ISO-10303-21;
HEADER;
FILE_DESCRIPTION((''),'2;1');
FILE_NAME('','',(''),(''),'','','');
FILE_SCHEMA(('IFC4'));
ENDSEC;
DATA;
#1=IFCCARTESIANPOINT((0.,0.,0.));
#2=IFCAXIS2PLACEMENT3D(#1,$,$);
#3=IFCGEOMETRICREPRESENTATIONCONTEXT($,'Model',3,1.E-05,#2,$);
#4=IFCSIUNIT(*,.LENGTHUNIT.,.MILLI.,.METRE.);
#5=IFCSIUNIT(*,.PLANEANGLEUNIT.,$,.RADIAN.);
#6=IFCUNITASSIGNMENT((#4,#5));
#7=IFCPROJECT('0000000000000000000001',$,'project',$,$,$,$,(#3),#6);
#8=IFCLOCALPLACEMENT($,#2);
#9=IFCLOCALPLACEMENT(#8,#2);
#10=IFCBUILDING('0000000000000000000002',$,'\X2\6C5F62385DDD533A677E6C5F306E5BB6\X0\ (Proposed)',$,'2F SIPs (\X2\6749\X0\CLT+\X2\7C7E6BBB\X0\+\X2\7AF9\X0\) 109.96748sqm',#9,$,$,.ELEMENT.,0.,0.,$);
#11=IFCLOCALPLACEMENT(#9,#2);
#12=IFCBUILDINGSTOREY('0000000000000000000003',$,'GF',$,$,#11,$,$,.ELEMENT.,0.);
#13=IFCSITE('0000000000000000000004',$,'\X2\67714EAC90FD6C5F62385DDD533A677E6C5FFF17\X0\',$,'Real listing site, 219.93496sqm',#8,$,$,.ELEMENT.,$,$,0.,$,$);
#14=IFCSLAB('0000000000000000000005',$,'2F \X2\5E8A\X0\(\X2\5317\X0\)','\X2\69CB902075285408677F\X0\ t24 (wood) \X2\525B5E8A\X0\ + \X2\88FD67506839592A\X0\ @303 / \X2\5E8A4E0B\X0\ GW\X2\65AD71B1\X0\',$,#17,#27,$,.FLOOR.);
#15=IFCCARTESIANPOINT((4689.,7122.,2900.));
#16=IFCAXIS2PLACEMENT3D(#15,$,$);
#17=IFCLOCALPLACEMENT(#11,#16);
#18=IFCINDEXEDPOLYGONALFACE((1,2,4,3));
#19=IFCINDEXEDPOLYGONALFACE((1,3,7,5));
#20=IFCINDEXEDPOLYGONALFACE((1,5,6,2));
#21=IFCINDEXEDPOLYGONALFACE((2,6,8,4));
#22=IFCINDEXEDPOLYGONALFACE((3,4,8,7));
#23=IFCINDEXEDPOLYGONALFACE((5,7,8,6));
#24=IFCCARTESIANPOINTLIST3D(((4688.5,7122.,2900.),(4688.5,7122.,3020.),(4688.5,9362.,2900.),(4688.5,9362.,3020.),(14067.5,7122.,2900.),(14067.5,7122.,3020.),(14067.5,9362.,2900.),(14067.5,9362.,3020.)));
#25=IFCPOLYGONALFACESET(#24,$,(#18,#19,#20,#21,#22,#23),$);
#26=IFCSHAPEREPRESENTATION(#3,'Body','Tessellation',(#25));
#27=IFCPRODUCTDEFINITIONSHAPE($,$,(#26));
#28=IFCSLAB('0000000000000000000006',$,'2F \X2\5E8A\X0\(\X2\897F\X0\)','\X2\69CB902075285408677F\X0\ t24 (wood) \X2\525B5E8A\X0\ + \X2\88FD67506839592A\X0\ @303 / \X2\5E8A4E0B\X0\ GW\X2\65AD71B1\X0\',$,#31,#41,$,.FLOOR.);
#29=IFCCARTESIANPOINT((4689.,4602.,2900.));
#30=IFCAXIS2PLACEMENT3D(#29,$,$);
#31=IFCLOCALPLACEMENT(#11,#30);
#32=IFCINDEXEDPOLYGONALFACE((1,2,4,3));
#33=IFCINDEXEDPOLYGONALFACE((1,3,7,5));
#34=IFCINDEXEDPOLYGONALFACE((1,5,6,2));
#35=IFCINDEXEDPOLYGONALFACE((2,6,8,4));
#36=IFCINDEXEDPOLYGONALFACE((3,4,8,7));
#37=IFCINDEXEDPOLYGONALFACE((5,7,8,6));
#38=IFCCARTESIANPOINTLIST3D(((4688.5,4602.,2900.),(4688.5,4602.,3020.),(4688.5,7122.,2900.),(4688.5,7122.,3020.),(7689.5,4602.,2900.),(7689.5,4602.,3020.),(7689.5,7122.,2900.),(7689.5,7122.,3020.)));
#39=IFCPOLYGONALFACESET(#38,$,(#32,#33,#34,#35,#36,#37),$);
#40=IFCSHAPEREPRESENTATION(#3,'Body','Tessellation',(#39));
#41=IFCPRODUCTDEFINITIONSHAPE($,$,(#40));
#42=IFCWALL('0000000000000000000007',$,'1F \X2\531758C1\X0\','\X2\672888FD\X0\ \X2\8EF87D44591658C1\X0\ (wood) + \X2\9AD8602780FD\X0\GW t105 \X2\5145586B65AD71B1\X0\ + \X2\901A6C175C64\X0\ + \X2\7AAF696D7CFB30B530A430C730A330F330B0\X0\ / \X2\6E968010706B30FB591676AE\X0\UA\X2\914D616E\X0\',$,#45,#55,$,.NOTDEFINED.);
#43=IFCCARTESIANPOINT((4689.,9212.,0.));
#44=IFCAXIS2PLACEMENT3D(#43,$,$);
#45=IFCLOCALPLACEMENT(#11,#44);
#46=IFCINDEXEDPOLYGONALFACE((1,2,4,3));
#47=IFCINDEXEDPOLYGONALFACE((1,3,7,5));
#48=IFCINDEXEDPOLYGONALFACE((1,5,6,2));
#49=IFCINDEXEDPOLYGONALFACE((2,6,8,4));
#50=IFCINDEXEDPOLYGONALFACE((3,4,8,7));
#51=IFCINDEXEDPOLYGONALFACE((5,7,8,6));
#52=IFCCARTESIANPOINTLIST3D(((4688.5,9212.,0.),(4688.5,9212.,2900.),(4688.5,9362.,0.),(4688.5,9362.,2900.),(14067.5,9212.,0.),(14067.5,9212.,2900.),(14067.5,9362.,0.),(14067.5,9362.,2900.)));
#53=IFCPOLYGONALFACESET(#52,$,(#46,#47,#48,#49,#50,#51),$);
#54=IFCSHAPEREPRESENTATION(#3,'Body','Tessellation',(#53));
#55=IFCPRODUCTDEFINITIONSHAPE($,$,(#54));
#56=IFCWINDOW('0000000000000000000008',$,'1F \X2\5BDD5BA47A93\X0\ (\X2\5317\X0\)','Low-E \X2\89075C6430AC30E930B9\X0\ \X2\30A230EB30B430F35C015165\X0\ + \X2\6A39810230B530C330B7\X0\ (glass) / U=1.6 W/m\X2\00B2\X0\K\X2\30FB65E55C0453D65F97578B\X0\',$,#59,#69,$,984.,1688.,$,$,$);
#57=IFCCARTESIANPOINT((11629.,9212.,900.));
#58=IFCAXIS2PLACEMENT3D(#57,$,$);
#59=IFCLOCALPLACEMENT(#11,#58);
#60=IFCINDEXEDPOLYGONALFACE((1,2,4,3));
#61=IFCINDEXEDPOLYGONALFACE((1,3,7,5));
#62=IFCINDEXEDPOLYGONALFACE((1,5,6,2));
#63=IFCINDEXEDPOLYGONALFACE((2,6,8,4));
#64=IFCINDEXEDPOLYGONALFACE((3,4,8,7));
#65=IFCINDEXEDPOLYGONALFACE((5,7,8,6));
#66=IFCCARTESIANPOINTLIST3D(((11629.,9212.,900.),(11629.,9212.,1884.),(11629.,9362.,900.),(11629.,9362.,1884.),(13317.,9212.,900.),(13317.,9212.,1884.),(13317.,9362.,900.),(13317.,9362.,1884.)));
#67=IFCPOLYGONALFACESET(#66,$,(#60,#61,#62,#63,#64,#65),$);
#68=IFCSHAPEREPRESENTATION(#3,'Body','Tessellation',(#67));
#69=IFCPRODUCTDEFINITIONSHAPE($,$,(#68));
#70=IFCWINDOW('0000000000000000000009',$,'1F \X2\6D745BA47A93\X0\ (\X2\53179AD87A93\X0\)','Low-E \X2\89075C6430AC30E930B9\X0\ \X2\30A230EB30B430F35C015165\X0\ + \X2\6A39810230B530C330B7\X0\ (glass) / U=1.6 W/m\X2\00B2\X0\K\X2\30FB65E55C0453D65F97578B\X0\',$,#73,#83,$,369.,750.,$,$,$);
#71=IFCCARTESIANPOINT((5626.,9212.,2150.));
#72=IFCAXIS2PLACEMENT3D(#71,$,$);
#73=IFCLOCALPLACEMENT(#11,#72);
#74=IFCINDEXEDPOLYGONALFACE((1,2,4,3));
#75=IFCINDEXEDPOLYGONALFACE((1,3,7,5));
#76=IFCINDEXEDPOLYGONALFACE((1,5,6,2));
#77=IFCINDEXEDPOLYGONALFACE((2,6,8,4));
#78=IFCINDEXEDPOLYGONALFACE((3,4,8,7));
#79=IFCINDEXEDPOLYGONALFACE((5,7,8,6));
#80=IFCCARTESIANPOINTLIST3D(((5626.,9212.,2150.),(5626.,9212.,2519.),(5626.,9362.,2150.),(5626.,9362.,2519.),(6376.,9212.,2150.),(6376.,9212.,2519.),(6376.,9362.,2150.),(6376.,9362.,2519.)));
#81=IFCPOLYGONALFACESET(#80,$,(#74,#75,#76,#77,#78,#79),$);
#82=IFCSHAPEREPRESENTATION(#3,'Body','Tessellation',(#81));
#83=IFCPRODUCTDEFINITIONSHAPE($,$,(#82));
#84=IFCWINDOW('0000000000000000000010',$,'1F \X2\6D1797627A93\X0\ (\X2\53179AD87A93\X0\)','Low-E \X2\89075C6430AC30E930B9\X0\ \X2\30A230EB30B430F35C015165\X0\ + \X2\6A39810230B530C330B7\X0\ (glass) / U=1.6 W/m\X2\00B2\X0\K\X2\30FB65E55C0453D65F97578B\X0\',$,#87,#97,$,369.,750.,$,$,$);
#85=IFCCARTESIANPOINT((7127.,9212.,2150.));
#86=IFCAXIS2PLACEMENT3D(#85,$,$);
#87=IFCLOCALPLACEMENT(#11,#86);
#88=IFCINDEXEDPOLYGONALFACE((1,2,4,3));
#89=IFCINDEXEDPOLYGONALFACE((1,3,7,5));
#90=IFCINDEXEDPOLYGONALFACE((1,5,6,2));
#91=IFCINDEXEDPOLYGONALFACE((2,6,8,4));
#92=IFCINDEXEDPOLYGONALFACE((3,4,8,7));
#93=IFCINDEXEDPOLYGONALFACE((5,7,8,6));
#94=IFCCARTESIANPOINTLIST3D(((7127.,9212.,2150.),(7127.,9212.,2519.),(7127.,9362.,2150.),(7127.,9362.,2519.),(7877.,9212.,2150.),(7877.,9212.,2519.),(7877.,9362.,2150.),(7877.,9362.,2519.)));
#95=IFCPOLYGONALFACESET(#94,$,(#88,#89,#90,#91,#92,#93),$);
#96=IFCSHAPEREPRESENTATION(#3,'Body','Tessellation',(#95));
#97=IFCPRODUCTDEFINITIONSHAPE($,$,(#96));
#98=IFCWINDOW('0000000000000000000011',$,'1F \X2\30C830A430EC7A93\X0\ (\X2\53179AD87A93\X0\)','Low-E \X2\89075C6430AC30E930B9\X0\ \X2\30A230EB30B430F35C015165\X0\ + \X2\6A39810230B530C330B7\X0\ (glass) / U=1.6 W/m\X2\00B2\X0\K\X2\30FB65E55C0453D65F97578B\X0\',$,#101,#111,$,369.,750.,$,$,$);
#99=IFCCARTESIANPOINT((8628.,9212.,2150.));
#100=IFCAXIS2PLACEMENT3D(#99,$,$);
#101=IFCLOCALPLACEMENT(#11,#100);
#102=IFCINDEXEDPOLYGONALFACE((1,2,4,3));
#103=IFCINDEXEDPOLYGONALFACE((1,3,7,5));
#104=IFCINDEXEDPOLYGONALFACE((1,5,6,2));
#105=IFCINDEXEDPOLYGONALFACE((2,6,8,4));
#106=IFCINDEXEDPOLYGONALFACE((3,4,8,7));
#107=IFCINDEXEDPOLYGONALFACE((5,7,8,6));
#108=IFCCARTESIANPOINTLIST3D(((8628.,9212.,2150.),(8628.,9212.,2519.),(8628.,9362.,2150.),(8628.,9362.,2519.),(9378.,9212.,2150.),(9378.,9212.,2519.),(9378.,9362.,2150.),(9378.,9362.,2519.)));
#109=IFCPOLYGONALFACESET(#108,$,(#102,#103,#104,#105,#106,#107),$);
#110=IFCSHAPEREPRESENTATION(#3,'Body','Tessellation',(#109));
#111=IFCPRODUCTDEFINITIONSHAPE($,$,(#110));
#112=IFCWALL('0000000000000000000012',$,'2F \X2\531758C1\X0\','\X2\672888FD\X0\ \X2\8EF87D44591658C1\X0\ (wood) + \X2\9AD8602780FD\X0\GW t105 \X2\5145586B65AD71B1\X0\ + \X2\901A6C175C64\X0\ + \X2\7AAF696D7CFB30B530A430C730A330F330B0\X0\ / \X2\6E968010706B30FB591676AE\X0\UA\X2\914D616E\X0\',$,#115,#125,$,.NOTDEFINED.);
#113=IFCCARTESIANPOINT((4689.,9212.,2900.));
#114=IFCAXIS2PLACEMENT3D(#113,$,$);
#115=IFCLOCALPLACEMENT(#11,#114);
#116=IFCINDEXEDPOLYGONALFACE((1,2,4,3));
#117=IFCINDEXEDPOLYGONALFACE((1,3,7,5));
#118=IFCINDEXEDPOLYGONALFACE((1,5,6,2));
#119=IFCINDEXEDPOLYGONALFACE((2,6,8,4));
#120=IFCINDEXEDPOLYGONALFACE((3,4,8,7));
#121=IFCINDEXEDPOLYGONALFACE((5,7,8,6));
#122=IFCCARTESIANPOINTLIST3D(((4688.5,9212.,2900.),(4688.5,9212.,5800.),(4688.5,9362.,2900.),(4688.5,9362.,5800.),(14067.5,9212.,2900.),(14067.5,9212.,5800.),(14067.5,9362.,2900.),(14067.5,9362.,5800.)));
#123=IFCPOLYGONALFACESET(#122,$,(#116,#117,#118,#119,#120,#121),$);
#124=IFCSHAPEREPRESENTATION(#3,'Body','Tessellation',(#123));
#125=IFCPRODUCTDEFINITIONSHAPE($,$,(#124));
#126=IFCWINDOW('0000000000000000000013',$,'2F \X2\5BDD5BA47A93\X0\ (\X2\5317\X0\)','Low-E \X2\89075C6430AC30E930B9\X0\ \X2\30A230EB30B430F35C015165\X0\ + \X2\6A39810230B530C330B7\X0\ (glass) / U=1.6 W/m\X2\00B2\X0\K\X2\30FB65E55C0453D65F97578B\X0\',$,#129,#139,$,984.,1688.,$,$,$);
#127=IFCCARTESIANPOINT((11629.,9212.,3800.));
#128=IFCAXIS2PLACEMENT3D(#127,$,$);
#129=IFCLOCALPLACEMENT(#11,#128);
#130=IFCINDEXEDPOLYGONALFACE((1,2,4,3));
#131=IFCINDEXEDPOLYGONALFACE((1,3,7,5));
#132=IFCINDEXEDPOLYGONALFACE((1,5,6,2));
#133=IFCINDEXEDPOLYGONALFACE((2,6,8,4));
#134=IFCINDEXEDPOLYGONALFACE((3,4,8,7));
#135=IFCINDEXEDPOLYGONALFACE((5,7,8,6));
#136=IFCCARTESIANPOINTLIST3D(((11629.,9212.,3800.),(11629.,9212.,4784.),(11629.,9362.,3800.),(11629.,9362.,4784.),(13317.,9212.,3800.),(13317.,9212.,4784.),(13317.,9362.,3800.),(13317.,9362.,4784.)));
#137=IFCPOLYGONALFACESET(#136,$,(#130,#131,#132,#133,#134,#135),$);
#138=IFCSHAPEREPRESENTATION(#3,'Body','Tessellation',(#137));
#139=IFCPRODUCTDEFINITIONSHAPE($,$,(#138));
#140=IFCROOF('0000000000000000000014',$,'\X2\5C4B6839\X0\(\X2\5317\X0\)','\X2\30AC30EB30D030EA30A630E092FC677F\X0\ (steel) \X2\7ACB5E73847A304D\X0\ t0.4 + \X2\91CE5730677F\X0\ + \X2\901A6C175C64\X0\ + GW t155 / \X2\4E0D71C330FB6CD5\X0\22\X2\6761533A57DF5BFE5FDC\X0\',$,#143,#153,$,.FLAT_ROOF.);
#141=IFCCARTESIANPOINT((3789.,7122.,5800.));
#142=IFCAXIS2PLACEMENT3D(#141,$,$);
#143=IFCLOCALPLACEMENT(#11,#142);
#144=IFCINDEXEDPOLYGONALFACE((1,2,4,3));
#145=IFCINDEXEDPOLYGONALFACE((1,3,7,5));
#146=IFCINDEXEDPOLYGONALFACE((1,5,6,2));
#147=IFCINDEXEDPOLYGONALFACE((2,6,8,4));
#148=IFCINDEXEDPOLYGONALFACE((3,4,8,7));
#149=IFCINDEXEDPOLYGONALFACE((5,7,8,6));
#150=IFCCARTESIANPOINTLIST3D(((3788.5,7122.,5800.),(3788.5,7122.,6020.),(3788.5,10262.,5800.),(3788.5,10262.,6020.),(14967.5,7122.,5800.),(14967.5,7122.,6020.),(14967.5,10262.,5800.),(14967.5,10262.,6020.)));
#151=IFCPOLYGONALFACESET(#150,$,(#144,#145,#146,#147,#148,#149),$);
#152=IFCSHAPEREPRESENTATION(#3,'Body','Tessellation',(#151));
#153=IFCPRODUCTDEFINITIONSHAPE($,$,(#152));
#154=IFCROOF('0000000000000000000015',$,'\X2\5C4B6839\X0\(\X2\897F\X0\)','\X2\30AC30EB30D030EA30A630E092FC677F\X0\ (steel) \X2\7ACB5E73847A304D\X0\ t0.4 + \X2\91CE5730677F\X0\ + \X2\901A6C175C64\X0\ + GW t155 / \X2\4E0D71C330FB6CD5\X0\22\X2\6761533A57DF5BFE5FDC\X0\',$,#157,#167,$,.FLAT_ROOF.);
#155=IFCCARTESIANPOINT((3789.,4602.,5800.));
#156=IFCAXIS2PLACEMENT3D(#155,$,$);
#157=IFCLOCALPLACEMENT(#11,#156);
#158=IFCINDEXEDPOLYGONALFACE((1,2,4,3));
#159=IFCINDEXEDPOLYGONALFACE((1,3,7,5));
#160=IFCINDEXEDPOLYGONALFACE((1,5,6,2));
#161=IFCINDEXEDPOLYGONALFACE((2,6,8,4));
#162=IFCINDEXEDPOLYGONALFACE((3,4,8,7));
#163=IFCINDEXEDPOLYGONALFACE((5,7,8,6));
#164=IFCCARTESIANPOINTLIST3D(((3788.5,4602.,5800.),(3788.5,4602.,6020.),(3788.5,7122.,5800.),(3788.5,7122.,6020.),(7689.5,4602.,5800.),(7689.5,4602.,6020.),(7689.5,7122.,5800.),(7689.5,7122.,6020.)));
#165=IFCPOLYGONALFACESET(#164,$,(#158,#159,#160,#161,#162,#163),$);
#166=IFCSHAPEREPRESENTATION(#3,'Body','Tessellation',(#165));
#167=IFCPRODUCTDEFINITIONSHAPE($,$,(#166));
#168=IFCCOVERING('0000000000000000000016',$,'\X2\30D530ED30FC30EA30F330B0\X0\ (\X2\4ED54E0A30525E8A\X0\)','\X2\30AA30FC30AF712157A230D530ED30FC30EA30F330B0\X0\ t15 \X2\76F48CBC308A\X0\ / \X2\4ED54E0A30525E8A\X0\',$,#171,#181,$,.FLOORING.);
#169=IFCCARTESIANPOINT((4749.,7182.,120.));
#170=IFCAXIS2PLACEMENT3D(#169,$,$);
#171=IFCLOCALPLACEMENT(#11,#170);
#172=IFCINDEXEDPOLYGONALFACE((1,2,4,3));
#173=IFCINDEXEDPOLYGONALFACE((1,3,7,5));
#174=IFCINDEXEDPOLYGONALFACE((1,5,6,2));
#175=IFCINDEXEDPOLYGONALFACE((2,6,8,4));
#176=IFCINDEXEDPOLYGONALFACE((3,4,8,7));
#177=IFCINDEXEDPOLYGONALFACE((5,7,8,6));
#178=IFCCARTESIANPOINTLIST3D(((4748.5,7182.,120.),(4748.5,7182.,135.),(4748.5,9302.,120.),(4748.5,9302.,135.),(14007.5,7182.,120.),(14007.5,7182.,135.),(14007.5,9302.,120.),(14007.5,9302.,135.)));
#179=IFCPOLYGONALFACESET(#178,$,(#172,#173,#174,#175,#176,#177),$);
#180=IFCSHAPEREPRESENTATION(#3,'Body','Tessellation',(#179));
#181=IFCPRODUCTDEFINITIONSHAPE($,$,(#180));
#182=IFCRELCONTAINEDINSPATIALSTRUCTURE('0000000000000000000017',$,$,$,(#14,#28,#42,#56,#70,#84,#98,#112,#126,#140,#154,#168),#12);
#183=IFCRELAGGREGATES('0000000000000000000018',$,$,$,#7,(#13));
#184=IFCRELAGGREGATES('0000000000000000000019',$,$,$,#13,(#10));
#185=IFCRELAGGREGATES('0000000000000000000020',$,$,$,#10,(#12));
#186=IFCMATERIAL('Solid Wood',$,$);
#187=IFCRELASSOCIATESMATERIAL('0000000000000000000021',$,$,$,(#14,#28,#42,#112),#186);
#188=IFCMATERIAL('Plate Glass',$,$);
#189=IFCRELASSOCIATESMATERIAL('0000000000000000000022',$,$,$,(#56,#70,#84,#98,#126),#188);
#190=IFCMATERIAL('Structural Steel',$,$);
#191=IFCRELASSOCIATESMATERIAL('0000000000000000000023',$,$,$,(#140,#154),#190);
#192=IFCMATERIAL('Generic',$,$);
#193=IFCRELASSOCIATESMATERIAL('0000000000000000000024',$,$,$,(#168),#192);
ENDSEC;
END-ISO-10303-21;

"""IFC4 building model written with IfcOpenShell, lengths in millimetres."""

from ifc_helpers import new_model, si_unit, frame, frame_2d, origin, place, context, project, spatial, rectangle, extrude, material, element, fill, save


model = new_model("IFC4")

# Units and contexts
model_context = context("Model", 3, precision=1e-05, world=origin())
ifc_project = project(units=[si_unit("LENGTHUNIT", "METRE", prefix="MILLI"), si_unit("PLANEANGLEUNIT", "RADIAN")], contexts=[model_context])

# Site, building, storey
site_placement = place(None, origin())
site = spatial("IfcSite", under=ifc_project, at=site_placement, Name="東京都江戸川区松江７", ObjectType="Real listing site, 219.93496sqm", CompositionType="ELEMENT", RefElevation=0.0)
building_placement = place(site_placement, origin())
building = spatial("IfcBuilding", under=site, at=building_placement, Name="江戸川区松江の家 (Proposed)", ObjectType="2F SIPs (杉CLT+籾殻+竹) 109.96748sqm", CompositionType="ELEMENT", ElevationOfRefHeight=0.0, ElevationOfTerrain=0.0)
storey_placement = place(building_placement, origin())
storey = spatial("IfcBuildingStorey", under=building, at=storey_placement, Name="GF", CompositionType="ELEMENT", Elevation=0.0)

# Slabs
ifc_material_1 = material(Name="Solid Wood")
slab_1_placement = place(storey_placement, frame((4689.0, 7122.0, 2900.0)))
element("IfcSlab", 1, at=slab_1_placement, inside=storey, material=ifc_material_1, Name="2F 床(北)", Description="構造用合板 t24 (wood) 剛床 + 製材根太 @303 / 床下 GW断熱", PredefinedType="FLOOR", context=model_context, shape_type="SweptSolid", body=[
    extrude(rectangle(XDim=9379.0, YDim=2240.0, at=frame_2d((4689.0, 1120.0))), frame((4689.0, 7122.0, 2900.0)), (0.0, 0.0, 1.0), 120.0),
])
slab_2_placement = place(storey_placement, frame((4689.0, 4602.0, 2900.0)))
element("IfcSlab", 2, at=slab_2_placement, inside=storey, material=ifc_material_1, Name="2F 床(西)", Description="構造用合板 t24 (wood) 剛床 + 製材根太 @303 / 床下 GW断熱", PredefinedType="FLOOR", context=model_context, shape_type="SweptSolid", body=[
    extrude(rectangle(XDim=3001.0, YDim=2520.0, at=frame_2d((1500.0, 1260.0))), frame((4689.0, 4602.0, 2900.0)), (0.0, 0.0, 1.0), 120.0),
])

# Wall, openings, windows
wall_1_placement = place(storey_placement, frame((4689.0, 9212.0, 0.0)))
wall_1 = element("IfcWall", 3, at=wall_1_placement, inside=storey, material=ifc_material_1, Name="1F 北壁", Description="木製 軸組外壁 (wood) + 高性能GW t105 充填断熱 + 通気層 + 窯業系サイディング / 準耐火・外皮UA配慮", PredefinedType="NOTDEFINED", context=model_context, shape_type="SweptSolid", body=[
    extrude(rectangle(XDim=9379.0, YDim=150.0, at=frame_2d((4689.0, 75.0))), frame((4689.0, 9212.0, 0.0)), (0.0, 0.0, 1.0), 2900.0),
])
opening_1_placement = place(storey_placement, frame((11629.0, 9212.0, 900.0)))
opening_1 = element("IfcOpeningElement", 4, at=opening_1_placement, cuts=wall_1, PredefinedType="NOTDEFINED", context=model_context, shape_type="SweptSolid", body=[
    extrude(rectangle(XDim=1688.0, YDim=150.0, at=frame_2d((844.0, 75.0))), frame((11629.0, 9212.0, 900.0)), (0.0, 0.0, 1.0), 984.0),
])
opening_2_placement = place(storey_placement, frame((5626.0, 9212.0, 2150.0)))
opening_2 = element("IfcOpeningElement", 5, at=opening_2_placement, cuts=wall_1, PredefinedType="NOTDEFINED", context=model_context, shape_type="SweptSolid", body=[
    extrude(rectangle(XDim=750.0, YDim=150.0, at=frame_2d((375.0, 75.0))), frame((5626.0, 9212.0, 2150.0)), (0.0, 0.0, 1.0), 369.0),
])
opening_3_placement = place(storey_placement, frame((7127.0, 9212.0, 2150.0)))
opening_3 = element("IfcOpeningElement", 6, at=opening_3_placement, cuts=wall_1, PredefinedType="NOTDEFINED", context=model_context, shape_type="SweptSolid", body=[
    extrude(rectangle(XDim=750.0, YDim=150.0, at=frame_2d((375.0, 75.0))), frame((7127.0, 9212.0, 2150.0)), (0.0, 0.0, 1.0), 369.0),
])
opening_4_placement = place(storey_placement, frame((8628.0, 9212.0, 2150.0)))
opening_4 = element("IfcOpeningElement", 7, at=opening_4_placement, cuts=wall_1, PredefinedType="NOTDEFINED", context=model_context, shape_type="SweptSolid", body=[
    extrude(rectangle(XDim=750.0, YDim=150.0, at=frame_2d((375.0, 75.0))), frame((8628.0, 9212.0, 2150.0)), (0.0, 0.0, 1.0), 369.0),
])
ifc_material_2 = material(Name="Plate Glass")
window_1_placement = place(storey_placement, frame((11629.0, 9212.0, 900.0)))
window_1 = element("IfcWindow", 8, at=window_1_placement, inside=storey, material=ifc_material_2, Name="1F 寝室窓 (北)", Description="Low-E 複層ガラス アルゴン封入 + 樹脂サッシ (glass) / U=1.6 W/m²K・日射取得型", OverallHeight=984.0, OverallWidth=1688.0, context=model_context, shape_type="SweptSolid", body=[
    extrude(rectangle(XDim=1688.0, YDim=150.0, at=frame_2d((844.0, 75.0))), frame((11629.0, 9212.0, 900.0)), (0.0, 0.0, 1.0), 984.0),
])
fill(opening_1, window_1)
window_2_placement = place(storey_placement, frame((5626.0, 9212.0, 2150.0)))
window_2 = element("IfcWindow", 9, at=window_2_placement, inside=storey, material=ifc_material_2, Name="1F 浴室窓 (北高窓)", Description="Low-E 複層ガラス アルゴン封入 + 樹脂サッシ (glass) / U=1.6 W/m²K・日射取得型", OverallHeight=369.0, OverallWidth=750.0, context=model_context, shape_type="SweptSolid", body=[
    extrude(rectangle(XDim=750.0, YDim=150.0, at=frame_2d((375.0, 75.0))), frame((5626.0, 9212.0, 2150.0)), (0.0, 0.0, 1.0), 369.0),
])
fill(opening_2, window_2)
window_3_placement = place(storey_placement, frame((7127.0, 9212.0, 2150.0)))
window_3 = element("IfcWindow", 10, at=window_3_placement, inside=storey, material=ifc_material_2, Name="1F 洗面窓 (北高窓)", Description="Low-E 複層ガラス アルゴン封入 + 樹脂サッシ (glass) / U=1.6 W/m²K・日射取得型", OverallHeight=369.0, OverallWidth=750.0, context=model_context, shape_type="SweptSolid", body=[
    extrude(rectangle(XDim=750.0, YDim=150.0, at=frame_2d((375.0, 75.0))), frame((7127.0, 9212.0, 2150.0)), (0.0, 0.0, 1.0), 369.0),
])
fill(opening_3, window_3)
window_4_placement = place(storey_placement, frame((8628.0, 9212.0, 2150.0)))
window_4 = element("IfcWindow", 11, at=window_4_placement, inside=storey, material=ifc_material_2, Name="1F トイレ窓 (北高窓)", Description="Low-E 複層ガラス アルゴン封入 + 樹脂サッシ (glass) / U=1.6 W/m²K・日射取得型", OverallHeight=369.0, OverallWidth=750.0, context=model_context, shape_type="SweptSolid", body=[
    extrude(rectangle(XDim=750.0, YDim=150.0, at=frame_2d((375.0, 75.0))), frame((8628.0, 9212.0, 2150.0)), (0.0, 0.0, 1.0), 369.0),
])
fill(opening_4, window_4)

# Wall, opening, window
wall_2_placement = place(storey_placement, frame((4689.0, 9212.0, 2900.0)))
wall_2 = element("IfcWall", 12, at=wall_2_placement, inside=storey, material=ifc_material_1, Name="2F 北壁", Description="木製 軸組外壁 (wood) + 高性能GW t105 充填断熱 + 通気層 + 窯業系サイディング / 準耐火・外皮UA配慮", PredefinedType="NOTDEFINED", context=model_context, shape_type="SweptSolid", body=[
    extrude(rectangle(XDim=9379.0, YDim=150.0, at=frame_2d((4689.0, 75.0))), frame((4689.0, 9212.0, 2900.0)), (0.0, 0.0, 1.0), 2900.0),
])
opening_5_placement = place(storey_placement, frame((11629.0, 9212.0, 3800.0)))
opening_5 = element("IfcOpeningElement", 13, at=opening_5_placement, cuts=wall_2, PredefinedType="NOTDEFINED", context=model_context, shape_type="SweptSolid", body=[
    extrude(rectangle(XDim=1688.0, YDim=150.0, at=frame_2d((844.0, 75.0))), frame((11629.0, 9212.0, 3800.0)), (0.0, 0.0, 1.0), 984.0),
])
window_5_placement = place(storey_placement, frame((11629.0, 9212.0, 3800.0)))
window_5 = element("IfcWindow", 14, at=window_5_placement, inside=storey, material=ifc_material_2, Name="2F 寝室窓 (北)", Description="Low-E 複層ガラス アルゴン封入 + 樹脂サッシ (glass) / U=1.6 W/m²K・日射取得型", OverallHeight=984.0, OverallWidth=1688.0, context=model_context, shape_type="SweptSolid", body=[
    extrude(rectangle(XDim=1688.0, YDim=150.0, at=frame_2d((844.0, 75.0))), frame((11629.0, 9212.0, 3800.0)), (0.0, 0.0, 1.0), 984.0),
])
fill(opening_5, window_5)

# Roofs
ifc_material_3 = material(Name="Structural Steel")
for number, where, name in (
    (15, (3789.0, 7122.0, 5800.0), "屋根(北)"),
):
    element("IfcRoof", number, at=place(storey_placement, frame(where)), inside=storey, material=ifc_material_3, Name=name, Description="ガルバリウム鋼板 (steel) 立平葺き t0.4 + 野地板 + 通気層 + GW t155 / 不燃・法22条区域対応", PredefinedType="FLAT_ROOF", context=model_context, shape_type="SweptSolid", body=[
        extrude(rectangle(XDim=11179.0, YDim=3140.0, at=frame_2d((5589.0, 1570.0))), frame((3789.0, 7122.0, 5800.0)), (0.0, 0.0, 1.0), 220.0),
    ])
roof_placement = place(storey_placement, frame((3789.0, 4602.0, 5800.0)))
element("IfcRoof", 16, at=roof_placement, inside=storey, material=ifc_material_3, Name="屋根(西)", Description="ガルバリウム鋼板 (steel) 立平葺き t0.4 + 野地板 + 通気層 + GW t155 / 不燃・法22条区域対応", PredefinedType="FLAT_ROOF", context=model_context, shape_type="SweptSolid", body=[
    extrude(rectangle(XDim=3901.0, YDim=2520.0, at=frame_2d((1950.0, 1260.0))), frame((3789.0, 4602.0, 5800.0)), (0.0, 0.0, 1.0), 220.0),
])

# Covering
ifc_material_4 = material(Name="Generic")
covering_1_placement = place(storey_placement, frame((4749.0, 7182.0, 120.0)))
element("IfcCovering", 17, at=covering_1_placement, inside=storey, material=ifc_material_4, Name="フローリング (仕上げ床)", Description="オーク無垢フローリング t15 直貼り / 仕上げ床", PredefinedType="FLOORING", context=model_context, shape_type="SweptSolid", body=[
    extrude(rectangle(XDim=9259.0, YDim=2120.0, at=frame_2d((4629.0, 1060.0))), frame((4749.0, 7182.0, 120.0)), (0.0, 0.0, 1.0), 15.0),
])

save(model, "model.ifc")
